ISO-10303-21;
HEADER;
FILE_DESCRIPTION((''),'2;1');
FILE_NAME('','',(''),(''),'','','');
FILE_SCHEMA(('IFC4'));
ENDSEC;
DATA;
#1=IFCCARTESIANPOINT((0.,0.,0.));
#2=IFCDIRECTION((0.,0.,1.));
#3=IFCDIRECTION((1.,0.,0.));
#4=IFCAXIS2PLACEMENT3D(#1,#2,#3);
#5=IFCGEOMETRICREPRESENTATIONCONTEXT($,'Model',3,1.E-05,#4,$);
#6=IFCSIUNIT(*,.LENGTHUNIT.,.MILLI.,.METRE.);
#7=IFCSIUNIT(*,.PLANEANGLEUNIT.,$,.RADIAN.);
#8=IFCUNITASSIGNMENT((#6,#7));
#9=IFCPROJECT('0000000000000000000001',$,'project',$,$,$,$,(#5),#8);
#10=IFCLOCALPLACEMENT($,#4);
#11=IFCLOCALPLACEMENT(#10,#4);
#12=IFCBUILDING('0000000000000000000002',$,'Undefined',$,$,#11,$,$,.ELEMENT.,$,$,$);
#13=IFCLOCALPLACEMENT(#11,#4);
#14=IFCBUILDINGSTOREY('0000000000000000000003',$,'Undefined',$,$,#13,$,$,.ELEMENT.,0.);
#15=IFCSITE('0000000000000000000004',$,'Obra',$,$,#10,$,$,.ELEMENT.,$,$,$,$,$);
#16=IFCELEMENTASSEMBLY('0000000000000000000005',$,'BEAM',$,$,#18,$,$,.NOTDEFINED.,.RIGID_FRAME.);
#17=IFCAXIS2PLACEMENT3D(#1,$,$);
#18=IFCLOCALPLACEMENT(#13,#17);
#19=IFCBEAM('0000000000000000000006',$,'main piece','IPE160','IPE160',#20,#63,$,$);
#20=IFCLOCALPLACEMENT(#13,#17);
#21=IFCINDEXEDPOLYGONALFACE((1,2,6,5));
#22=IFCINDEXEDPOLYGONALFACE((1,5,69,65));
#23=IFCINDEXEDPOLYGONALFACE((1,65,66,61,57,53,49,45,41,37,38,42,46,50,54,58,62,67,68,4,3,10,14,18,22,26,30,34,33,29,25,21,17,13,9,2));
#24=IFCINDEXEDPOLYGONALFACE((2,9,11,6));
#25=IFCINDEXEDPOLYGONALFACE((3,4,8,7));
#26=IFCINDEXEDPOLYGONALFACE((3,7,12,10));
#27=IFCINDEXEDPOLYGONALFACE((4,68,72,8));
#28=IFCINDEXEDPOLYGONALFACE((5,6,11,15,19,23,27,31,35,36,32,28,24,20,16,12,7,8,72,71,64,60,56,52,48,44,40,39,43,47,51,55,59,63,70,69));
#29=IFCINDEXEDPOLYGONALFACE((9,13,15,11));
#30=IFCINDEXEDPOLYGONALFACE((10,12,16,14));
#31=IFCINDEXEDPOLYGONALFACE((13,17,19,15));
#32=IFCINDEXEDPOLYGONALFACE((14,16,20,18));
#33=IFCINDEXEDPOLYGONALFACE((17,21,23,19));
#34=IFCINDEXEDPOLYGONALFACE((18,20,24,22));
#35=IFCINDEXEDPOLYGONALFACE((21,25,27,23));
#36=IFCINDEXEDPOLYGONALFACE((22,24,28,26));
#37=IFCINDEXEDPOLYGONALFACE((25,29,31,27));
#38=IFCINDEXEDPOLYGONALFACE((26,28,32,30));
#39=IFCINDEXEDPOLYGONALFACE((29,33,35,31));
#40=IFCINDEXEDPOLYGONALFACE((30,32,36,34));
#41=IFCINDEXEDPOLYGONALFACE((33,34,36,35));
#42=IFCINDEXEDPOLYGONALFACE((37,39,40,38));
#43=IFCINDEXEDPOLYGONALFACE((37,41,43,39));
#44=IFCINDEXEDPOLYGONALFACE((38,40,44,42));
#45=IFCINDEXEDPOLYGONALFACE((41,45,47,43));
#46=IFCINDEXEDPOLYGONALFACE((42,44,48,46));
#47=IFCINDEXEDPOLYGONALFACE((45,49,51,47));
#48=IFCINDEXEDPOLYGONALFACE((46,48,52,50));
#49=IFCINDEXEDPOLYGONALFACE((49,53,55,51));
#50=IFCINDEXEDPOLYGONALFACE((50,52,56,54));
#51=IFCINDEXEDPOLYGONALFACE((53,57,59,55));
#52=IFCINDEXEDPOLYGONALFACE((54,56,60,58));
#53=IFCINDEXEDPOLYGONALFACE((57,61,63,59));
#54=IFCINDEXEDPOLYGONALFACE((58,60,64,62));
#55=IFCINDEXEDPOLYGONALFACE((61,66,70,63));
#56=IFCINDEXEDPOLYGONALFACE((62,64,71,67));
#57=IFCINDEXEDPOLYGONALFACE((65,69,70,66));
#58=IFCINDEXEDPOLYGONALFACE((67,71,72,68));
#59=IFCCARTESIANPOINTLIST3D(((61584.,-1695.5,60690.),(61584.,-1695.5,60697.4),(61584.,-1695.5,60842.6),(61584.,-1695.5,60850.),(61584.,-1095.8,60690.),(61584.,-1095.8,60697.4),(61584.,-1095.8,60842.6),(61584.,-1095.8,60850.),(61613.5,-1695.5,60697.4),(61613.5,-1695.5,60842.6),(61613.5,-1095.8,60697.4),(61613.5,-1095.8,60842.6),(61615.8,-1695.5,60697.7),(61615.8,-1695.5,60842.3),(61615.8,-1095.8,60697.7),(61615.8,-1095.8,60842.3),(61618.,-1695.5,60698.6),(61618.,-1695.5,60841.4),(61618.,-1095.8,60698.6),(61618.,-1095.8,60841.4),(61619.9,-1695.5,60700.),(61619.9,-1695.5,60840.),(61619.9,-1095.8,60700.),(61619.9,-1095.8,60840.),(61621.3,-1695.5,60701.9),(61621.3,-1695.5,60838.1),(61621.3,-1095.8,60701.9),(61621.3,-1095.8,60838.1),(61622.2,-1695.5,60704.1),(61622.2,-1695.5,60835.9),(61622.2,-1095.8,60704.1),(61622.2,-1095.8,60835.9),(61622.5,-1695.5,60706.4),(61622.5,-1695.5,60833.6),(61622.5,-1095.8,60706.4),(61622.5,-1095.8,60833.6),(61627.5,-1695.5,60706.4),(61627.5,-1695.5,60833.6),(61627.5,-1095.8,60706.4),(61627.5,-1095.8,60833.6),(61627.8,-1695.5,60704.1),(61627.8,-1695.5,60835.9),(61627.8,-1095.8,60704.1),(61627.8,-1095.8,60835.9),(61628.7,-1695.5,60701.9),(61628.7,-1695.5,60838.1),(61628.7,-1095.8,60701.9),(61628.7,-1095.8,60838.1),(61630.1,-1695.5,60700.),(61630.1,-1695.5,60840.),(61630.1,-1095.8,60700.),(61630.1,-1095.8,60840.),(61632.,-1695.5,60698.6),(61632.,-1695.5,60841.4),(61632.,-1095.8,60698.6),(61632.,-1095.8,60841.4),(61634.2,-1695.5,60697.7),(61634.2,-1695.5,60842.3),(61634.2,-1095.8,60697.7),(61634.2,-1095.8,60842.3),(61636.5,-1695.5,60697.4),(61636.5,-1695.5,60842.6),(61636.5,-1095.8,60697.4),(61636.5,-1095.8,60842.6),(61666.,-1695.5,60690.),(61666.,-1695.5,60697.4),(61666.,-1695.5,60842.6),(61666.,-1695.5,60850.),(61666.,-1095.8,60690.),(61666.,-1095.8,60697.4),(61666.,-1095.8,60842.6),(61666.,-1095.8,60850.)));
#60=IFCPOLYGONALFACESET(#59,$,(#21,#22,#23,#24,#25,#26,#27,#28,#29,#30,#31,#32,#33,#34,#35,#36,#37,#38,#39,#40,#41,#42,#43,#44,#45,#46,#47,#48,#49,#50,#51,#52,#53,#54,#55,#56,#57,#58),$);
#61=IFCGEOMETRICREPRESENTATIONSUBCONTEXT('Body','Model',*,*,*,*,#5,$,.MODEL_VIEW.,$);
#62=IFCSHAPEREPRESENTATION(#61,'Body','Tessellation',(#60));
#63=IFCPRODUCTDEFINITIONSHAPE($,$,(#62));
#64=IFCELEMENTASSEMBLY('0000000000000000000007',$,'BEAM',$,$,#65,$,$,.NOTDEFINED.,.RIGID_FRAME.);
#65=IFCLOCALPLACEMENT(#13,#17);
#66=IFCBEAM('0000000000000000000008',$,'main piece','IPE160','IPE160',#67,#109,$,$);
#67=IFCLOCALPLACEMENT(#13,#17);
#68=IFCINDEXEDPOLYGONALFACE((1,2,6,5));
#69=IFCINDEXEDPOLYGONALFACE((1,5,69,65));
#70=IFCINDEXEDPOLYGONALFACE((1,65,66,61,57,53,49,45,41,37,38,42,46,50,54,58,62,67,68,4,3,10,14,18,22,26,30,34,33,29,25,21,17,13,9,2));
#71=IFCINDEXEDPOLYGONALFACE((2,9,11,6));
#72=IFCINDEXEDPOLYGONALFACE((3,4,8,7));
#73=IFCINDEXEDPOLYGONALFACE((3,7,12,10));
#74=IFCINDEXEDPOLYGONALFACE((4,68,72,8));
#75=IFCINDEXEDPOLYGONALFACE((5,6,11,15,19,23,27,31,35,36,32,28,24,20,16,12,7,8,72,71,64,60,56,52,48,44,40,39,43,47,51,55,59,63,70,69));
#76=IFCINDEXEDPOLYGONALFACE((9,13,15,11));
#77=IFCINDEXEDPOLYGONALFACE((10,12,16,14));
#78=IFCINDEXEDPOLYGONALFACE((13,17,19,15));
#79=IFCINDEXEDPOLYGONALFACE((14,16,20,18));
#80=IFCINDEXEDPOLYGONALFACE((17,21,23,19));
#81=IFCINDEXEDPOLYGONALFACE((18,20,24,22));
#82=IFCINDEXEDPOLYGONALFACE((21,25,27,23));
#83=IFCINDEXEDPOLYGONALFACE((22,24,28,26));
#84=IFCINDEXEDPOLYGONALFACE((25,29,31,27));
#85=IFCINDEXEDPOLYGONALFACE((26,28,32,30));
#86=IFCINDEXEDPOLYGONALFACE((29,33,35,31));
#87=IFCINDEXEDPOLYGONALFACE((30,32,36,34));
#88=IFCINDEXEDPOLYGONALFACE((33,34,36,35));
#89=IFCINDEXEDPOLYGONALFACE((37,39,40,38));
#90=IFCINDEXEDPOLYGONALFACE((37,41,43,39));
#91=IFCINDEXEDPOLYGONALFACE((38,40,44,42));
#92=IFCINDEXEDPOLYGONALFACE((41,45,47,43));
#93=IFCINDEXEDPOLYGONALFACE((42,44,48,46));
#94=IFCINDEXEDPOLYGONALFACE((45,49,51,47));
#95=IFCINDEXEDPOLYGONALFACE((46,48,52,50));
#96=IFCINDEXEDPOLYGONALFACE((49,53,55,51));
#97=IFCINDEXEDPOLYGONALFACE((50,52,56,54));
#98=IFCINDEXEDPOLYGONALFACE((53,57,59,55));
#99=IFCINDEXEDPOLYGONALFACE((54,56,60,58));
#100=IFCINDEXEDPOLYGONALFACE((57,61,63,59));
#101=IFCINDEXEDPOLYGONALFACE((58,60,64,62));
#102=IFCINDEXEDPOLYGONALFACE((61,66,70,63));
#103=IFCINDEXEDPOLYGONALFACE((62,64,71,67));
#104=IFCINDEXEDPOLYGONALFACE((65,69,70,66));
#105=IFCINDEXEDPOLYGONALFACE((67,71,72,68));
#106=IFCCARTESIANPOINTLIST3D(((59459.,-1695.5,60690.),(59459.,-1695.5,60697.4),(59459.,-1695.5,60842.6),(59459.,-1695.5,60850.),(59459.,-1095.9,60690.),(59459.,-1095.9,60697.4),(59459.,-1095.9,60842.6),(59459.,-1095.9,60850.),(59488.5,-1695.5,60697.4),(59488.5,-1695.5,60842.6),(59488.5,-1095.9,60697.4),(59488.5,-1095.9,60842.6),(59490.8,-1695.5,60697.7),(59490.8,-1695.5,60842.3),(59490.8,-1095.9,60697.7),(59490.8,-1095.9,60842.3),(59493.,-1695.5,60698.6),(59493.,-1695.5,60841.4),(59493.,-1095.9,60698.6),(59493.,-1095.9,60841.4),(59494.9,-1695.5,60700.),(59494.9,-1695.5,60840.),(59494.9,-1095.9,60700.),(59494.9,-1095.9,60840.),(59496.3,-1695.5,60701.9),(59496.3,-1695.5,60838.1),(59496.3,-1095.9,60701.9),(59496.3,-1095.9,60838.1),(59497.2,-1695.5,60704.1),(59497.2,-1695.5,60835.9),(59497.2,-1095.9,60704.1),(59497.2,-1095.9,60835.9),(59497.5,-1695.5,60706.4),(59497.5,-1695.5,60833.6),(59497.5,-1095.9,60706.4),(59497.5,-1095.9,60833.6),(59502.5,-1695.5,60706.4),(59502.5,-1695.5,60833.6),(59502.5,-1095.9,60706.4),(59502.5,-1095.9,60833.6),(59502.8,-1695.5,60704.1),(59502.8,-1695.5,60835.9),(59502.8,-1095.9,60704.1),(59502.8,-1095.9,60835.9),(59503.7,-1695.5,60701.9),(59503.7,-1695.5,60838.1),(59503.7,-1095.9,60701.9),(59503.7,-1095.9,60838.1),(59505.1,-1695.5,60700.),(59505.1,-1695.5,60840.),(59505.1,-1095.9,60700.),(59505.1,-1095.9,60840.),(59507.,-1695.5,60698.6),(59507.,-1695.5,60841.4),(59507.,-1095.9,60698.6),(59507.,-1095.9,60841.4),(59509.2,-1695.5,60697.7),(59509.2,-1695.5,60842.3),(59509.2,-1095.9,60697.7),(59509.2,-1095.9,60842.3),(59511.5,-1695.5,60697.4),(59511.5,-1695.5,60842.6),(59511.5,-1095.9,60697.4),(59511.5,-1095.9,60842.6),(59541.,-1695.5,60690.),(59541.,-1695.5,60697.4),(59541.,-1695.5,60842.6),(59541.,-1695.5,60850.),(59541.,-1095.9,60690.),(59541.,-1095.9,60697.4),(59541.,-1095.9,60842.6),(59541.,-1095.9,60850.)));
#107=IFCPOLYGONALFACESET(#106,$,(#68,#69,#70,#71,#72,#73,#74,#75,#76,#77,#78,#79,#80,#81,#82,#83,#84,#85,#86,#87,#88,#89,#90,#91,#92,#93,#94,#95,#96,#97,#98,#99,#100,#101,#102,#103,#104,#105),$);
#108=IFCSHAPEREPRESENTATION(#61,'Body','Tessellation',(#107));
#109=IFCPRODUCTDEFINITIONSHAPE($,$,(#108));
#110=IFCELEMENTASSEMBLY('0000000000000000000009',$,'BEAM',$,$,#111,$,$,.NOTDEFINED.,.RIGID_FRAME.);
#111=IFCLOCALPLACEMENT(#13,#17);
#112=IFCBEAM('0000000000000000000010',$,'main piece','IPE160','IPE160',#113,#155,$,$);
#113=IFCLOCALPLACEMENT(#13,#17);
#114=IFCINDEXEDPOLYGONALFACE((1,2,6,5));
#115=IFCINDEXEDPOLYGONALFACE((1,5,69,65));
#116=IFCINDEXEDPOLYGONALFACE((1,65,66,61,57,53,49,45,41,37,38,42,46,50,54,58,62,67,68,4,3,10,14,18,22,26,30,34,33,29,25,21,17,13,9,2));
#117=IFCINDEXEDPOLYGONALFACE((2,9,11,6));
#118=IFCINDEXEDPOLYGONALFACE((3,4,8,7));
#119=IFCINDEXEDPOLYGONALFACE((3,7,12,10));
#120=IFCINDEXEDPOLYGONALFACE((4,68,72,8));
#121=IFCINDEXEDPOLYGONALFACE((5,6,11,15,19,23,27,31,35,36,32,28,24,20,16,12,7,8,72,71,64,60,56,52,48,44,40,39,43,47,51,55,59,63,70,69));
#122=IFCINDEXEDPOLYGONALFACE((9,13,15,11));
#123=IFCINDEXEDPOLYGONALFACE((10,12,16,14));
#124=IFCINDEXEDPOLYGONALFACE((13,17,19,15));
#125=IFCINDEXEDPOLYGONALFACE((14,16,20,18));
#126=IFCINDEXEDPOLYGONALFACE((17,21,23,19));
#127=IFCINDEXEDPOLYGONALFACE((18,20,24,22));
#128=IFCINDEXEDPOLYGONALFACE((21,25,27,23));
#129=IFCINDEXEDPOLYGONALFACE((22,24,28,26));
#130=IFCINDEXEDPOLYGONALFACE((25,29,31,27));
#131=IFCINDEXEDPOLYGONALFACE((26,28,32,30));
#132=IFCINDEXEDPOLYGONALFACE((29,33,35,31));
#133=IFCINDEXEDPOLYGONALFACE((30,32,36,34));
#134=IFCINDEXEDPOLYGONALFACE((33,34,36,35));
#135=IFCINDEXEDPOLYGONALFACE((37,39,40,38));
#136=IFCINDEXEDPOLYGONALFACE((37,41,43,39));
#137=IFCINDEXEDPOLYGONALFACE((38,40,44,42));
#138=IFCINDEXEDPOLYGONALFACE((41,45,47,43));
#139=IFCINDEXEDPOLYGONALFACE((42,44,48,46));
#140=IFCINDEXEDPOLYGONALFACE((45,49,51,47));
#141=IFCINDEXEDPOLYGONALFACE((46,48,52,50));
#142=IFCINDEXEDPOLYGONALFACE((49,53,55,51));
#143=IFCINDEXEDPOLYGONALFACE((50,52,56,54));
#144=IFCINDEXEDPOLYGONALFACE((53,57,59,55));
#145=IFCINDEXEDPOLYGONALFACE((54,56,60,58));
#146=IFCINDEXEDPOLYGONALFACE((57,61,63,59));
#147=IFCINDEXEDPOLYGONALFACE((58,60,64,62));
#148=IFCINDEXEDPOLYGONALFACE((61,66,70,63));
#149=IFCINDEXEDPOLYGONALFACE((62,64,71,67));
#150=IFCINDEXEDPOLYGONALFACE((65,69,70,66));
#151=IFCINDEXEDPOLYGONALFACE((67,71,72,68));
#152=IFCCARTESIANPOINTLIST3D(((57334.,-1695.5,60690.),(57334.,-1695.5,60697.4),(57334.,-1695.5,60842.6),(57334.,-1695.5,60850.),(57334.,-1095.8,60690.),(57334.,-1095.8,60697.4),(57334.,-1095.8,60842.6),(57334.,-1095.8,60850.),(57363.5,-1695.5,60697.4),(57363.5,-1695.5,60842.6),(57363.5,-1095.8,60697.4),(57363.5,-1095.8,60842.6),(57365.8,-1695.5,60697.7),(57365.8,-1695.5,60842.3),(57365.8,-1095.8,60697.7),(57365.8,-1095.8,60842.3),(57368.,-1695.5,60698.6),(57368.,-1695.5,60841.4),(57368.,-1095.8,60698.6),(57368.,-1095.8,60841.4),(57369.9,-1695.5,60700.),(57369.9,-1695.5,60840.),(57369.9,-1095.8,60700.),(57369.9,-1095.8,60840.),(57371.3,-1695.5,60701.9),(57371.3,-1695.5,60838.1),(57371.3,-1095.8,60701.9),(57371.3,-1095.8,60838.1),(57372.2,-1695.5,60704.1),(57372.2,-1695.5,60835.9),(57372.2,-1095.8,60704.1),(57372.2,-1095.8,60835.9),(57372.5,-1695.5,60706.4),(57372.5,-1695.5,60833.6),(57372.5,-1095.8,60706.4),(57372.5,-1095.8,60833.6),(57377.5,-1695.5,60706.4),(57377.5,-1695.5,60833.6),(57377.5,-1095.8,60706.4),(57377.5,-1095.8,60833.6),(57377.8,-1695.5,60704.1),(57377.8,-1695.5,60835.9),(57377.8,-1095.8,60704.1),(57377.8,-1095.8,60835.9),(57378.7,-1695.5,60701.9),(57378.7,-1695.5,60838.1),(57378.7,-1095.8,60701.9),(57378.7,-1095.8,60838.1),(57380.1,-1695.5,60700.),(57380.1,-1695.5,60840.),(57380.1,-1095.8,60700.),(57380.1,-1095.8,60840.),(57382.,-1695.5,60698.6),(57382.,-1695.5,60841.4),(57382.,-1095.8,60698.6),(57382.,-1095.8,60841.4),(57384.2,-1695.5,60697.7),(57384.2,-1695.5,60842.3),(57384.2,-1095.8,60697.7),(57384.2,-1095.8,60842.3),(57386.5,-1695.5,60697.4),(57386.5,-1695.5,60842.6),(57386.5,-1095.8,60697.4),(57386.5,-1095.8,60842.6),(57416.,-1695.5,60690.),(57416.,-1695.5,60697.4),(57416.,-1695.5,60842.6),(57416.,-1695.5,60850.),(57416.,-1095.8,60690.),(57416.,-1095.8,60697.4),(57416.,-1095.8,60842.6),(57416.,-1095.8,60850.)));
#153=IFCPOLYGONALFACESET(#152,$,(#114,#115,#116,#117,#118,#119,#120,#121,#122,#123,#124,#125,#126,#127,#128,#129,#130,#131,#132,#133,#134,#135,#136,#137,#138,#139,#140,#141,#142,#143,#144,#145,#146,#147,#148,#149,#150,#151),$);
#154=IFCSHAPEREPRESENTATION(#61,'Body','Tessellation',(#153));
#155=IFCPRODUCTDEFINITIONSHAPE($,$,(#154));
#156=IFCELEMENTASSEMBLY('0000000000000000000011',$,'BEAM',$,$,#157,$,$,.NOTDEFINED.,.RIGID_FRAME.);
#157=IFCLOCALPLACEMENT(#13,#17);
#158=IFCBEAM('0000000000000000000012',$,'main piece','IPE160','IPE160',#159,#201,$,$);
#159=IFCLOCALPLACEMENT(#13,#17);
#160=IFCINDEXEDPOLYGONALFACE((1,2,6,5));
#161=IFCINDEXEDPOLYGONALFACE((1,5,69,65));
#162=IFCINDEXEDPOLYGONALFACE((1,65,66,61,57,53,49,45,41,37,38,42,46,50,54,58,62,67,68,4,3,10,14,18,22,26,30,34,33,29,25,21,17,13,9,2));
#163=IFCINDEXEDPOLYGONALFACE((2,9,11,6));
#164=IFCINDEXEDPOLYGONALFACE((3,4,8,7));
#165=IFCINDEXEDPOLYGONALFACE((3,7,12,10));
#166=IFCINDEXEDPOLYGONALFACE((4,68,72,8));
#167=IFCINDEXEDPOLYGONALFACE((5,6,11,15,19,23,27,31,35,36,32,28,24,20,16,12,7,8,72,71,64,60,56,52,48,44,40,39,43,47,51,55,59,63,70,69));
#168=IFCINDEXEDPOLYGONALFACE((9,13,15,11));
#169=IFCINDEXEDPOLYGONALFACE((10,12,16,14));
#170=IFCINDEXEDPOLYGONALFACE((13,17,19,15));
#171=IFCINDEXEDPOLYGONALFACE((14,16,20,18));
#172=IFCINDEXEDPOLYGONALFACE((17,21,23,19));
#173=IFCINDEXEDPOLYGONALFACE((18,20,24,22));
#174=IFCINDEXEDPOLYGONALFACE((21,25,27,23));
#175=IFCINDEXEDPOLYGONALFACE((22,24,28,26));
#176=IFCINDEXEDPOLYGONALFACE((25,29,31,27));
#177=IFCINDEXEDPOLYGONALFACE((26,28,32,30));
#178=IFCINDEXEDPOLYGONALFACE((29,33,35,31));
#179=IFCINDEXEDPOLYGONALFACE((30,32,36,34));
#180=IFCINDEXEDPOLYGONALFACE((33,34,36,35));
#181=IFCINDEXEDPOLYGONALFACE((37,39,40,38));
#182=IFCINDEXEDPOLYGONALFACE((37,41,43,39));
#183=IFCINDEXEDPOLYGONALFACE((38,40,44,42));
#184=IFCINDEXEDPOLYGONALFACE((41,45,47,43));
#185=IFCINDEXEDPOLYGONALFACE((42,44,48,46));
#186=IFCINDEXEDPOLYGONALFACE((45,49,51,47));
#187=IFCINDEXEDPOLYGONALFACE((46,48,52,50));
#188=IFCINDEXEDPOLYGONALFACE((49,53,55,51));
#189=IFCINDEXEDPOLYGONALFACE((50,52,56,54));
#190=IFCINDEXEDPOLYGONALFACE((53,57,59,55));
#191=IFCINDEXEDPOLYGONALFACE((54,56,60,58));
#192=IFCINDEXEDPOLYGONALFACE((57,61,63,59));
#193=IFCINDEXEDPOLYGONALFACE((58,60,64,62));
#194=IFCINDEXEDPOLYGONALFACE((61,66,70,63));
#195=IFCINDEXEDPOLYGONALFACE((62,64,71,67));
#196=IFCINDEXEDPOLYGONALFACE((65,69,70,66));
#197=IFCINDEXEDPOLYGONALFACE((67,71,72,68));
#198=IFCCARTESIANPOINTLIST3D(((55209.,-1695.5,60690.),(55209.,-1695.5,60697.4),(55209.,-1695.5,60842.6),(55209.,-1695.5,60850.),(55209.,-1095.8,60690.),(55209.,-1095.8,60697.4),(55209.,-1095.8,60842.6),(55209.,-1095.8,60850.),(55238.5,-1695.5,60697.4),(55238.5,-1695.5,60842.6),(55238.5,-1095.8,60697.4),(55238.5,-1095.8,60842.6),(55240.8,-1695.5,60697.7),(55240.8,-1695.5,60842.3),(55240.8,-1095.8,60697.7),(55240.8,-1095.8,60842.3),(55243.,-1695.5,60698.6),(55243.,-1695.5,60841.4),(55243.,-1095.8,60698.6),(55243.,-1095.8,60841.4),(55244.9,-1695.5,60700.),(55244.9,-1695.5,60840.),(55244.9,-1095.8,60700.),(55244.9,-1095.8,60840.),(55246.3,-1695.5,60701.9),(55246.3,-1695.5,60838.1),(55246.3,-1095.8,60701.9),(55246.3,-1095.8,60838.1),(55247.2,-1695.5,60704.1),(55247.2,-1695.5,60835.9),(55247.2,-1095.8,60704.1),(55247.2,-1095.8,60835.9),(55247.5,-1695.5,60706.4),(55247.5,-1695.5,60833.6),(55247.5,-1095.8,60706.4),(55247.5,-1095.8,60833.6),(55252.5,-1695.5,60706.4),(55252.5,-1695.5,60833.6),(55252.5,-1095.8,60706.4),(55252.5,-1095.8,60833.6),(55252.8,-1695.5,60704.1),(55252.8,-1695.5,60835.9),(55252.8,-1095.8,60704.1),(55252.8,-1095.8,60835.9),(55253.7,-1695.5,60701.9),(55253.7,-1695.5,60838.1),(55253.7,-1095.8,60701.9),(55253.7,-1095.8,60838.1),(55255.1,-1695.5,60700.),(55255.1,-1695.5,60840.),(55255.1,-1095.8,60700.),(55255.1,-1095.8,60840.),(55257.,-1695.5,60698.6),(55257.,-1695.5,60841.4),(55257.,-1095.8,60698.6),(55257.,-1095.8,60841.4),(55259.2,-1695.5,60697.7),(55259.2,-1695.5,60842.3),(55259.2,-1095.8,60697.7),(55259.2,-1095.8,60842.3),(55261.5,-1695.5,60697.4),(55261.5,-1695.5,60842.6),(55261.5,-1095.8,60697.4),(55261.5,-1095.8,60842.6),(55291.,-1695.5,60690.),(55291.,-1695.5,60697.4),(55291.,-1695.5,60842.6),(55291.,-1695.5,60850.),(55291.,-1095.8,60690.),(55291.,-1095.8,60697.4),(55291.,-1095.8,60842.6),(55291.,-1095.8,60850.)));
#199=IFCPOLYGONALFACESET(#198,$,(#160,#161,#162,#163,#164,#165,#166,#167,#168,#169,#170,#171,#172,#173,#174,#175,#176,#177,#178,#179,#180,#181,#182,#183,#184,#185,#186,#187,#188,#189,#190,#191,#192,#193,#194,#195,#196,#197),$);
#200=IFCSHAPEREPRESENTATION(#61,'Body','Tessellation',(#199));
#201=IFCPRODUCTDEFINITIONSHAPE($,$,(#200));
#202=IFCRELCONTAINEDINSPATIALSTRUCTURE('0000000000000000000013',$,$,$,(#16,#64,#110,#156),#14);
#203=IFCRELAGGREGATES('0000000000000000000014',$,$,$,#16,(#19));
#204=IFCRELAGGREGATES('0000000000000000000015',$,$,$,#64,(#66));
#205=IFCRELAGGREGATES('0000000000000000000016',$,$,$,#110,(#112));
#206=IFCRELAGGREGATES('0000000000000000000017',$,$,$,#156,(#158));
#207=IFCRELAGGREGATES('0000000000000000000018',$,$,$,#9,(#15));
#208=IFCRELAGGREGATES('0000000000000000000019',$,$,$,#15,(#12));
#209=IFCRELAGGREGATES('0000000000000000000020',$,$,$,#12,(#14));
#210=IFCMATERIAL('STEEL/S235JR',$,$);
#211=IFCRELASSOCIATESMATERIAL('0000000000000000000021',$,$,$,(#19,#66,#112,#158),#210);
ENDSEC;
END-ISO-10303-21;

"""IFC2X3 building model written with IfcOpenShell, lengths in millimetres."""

from ifc_helpers import new_model, si_unit, frame, origin_with_axes, origin_2d_with_axis, place, context, subcontext, project, spatial, i_section, extrude, material, element, aggregate, save


model = new_model("IFC2X3")

# Units and contexts
model_context = context("Model", 3, precision=1e-05, world=origin_with_axes())
body_context = subcontext(model_context, "Body", "Model", "MODEL_VIEW")
ifc_project = project(units=[si_unit("LENGTHUNIT", "METRE", prefix="MILLI"), si_unit("PLANEANGLEUNIT", "RADIAN")], contexts=[model_context])

# Site, building, storey
site_placement = place(None, origin_with_axes())
site = spatial("IfcSite", under=ifc_project, at=site_placement, Name="Obra", CompositionType="ELEMENT")
building_placement = place(site_placement, origin_with_axes())
building = spatial("IfcBuilding", under=site, at=building_placement, Name="Undefined", CompositionType="ELEMENT")
storey_placement = place(building_placement, origin_with_axes())
storey = spatial("IfcBuildingStorey", under=building, at=storey_placement, Name="Undefined", CompositionType="ELEMENT", Elevation=0.0)

# Element assemblies, beams
assembly_1_placement = place(storey_placement, origin_with_axes())
assembly_1 = element("IfcElementAssembly", 1, at=assembly_1_placement, inside=storey, Name="BEAM", AssemblyPlace="NOTDEFINED", PredefinedType="RIGID_FRAME")
ifc_material_1 = material(Name="STEEL/S235JR")
beam_1_placement = place(assembly_1_placement, frame((61625.0, -1095.8, 60770.0), z_axis=(0.0, 0.0, 1.0), x_axis=(0.0, -1.0, 0.0)))
beam_1 = element("IfcBeam", 2, at=beam_1_placement, material=ifc_material_1, Name="main piece", Description="IPE160", ObjectType="IPE160", context=body_context, shape_type="SweptSolid", body=[
    extrude(i_section(OverallWidth=82.0, OverallDepth=160.0, WebThickness=5.0, FlangeThickness=7.4, FilletRadius=9.0, at=origin_2d_with_axis()), frame((599.7, 0.0, 0.0), z_axis=(-1.0, 0.0, 0.0), x_axis=(0.0, -1.0, 0.0)), (0.0, 0.0, 1.0), 599.7),
])
aggregate(assembly_1, [beam_1])
assembly_2_placement = place(storey_placement, origin_with_axes())
assembly_2 = element("IfcElementAssembly", 3, at=assembly_2_placement, inside=storey, Name="BEAM", AssemblyPlace="NOTDEFINED", PredefinedType="RIGID_FRAME")
beam_2_placement = place(assembly_2_placement, frame((59500.0, -1095.9, 60770.0), z_axis=(0.0, 0.0, 1.0), x_axis=(0.0, -1.0, 0.0)))
beam_2 = element("IfcBeam", 4, at=beam_2_placement, material=ifc_material_1, Name="main piece", Description="IPE160", ObjectType="IPE160", context=body_context, shape_type="SweptSolid", body=[
    extrude(i_section(OverallWidth=82.0, OverallDepth=160.0, WebThickness=5.0, FlangeThickness=7.4, FilletRadius=9.0, at=origin_2d_with_axis()), frame((599.6, 0.0, 0.0), z_axis=(-1.0, 0.0, 0.0), x_axis=(0.0, -1.0, 0.0)), (0.0, 0.0, 1.0), 599.6),
])
aggregate(assembly_2, [beam_2])
assembly_3_placement = place(storey_placement, origin_with_axes())
assembly_3 = element("IfcElementAssembly", 5, at=assembly_3_placement, inside=storey, Name="BEAM", AssemblyPlace="NOTDEFINED", PredefinedType="RIGID_FRAME")
beam_3_placement = place(assembly_3_placement, frame((57375.0, -1095.8, 60770.0), z_axis=(0.0, 0.0, 1.0), x_axis=(0.0, -1.0, 0.0)))
beam_3 = element("IfcBeam", 6, at=beam_3_placement, material=ifc_material_1, Name="main piece", Description="IPE160", ObjectType="IPE160", context=body_context, shape_type="SweptSolid", body=[
    extrude(i_section(OverallWidth=82.0, OverallDepth=160.0, WebThickness=5.0, FlangeThickness=7.4, FilletRadius=9.0, at=origin_2d_with_axis()), frame((599.7, 0.0, 0.0), z_axis=(-1.0, 0.0, 0.0), x_axis=(0.0, -1.0, 0.0)), (0.0, 0.0, 1.0), 599.7),
])
aggregate(assembly_3, [beam_3])
assembly_4_placement = place(storey_placement, origin_with_axes())
assembly_4 = element("IfcElementAssembly", 7, at=assembly_4_placement, inside=storey, Name="BEAM", AssemblyPlace="NOTDEFINED", PredefinedType="RIGID_FRAME")
beam_4_placement = place(assembly_4_placement, frame((55250.0, -1095.8, 60770.0), z_axis=(0.0, 0.0, 1.0), x_axis=(0.0, -1.0, 0.0)))
beam_4 = element("IfcBeam", 8, at=beam_4_placement, material=ifc_material_1, Name="main piece", Description="IPE160", ObjectType="IPE160", context=body_context, shape_type="SweptSolid", body=[
    extrude(i_section(OverallWidth=82.0, OverallDepth=160.0, WebThickness=5.0, FlangeThickness=7.4, FilletRadius=9.0, at=origin_2d_with_axis()), frame((599.7, 0.0, 0.0), z_axis=(-1.0, 0.0, 0.0), x_axis=(0.0, -1.0, 0.0)), (0.0, 0.0, 1.0), 599.7),
])
aggregate(assembly_4, [beam_4])

save(model, "model.ifc")
